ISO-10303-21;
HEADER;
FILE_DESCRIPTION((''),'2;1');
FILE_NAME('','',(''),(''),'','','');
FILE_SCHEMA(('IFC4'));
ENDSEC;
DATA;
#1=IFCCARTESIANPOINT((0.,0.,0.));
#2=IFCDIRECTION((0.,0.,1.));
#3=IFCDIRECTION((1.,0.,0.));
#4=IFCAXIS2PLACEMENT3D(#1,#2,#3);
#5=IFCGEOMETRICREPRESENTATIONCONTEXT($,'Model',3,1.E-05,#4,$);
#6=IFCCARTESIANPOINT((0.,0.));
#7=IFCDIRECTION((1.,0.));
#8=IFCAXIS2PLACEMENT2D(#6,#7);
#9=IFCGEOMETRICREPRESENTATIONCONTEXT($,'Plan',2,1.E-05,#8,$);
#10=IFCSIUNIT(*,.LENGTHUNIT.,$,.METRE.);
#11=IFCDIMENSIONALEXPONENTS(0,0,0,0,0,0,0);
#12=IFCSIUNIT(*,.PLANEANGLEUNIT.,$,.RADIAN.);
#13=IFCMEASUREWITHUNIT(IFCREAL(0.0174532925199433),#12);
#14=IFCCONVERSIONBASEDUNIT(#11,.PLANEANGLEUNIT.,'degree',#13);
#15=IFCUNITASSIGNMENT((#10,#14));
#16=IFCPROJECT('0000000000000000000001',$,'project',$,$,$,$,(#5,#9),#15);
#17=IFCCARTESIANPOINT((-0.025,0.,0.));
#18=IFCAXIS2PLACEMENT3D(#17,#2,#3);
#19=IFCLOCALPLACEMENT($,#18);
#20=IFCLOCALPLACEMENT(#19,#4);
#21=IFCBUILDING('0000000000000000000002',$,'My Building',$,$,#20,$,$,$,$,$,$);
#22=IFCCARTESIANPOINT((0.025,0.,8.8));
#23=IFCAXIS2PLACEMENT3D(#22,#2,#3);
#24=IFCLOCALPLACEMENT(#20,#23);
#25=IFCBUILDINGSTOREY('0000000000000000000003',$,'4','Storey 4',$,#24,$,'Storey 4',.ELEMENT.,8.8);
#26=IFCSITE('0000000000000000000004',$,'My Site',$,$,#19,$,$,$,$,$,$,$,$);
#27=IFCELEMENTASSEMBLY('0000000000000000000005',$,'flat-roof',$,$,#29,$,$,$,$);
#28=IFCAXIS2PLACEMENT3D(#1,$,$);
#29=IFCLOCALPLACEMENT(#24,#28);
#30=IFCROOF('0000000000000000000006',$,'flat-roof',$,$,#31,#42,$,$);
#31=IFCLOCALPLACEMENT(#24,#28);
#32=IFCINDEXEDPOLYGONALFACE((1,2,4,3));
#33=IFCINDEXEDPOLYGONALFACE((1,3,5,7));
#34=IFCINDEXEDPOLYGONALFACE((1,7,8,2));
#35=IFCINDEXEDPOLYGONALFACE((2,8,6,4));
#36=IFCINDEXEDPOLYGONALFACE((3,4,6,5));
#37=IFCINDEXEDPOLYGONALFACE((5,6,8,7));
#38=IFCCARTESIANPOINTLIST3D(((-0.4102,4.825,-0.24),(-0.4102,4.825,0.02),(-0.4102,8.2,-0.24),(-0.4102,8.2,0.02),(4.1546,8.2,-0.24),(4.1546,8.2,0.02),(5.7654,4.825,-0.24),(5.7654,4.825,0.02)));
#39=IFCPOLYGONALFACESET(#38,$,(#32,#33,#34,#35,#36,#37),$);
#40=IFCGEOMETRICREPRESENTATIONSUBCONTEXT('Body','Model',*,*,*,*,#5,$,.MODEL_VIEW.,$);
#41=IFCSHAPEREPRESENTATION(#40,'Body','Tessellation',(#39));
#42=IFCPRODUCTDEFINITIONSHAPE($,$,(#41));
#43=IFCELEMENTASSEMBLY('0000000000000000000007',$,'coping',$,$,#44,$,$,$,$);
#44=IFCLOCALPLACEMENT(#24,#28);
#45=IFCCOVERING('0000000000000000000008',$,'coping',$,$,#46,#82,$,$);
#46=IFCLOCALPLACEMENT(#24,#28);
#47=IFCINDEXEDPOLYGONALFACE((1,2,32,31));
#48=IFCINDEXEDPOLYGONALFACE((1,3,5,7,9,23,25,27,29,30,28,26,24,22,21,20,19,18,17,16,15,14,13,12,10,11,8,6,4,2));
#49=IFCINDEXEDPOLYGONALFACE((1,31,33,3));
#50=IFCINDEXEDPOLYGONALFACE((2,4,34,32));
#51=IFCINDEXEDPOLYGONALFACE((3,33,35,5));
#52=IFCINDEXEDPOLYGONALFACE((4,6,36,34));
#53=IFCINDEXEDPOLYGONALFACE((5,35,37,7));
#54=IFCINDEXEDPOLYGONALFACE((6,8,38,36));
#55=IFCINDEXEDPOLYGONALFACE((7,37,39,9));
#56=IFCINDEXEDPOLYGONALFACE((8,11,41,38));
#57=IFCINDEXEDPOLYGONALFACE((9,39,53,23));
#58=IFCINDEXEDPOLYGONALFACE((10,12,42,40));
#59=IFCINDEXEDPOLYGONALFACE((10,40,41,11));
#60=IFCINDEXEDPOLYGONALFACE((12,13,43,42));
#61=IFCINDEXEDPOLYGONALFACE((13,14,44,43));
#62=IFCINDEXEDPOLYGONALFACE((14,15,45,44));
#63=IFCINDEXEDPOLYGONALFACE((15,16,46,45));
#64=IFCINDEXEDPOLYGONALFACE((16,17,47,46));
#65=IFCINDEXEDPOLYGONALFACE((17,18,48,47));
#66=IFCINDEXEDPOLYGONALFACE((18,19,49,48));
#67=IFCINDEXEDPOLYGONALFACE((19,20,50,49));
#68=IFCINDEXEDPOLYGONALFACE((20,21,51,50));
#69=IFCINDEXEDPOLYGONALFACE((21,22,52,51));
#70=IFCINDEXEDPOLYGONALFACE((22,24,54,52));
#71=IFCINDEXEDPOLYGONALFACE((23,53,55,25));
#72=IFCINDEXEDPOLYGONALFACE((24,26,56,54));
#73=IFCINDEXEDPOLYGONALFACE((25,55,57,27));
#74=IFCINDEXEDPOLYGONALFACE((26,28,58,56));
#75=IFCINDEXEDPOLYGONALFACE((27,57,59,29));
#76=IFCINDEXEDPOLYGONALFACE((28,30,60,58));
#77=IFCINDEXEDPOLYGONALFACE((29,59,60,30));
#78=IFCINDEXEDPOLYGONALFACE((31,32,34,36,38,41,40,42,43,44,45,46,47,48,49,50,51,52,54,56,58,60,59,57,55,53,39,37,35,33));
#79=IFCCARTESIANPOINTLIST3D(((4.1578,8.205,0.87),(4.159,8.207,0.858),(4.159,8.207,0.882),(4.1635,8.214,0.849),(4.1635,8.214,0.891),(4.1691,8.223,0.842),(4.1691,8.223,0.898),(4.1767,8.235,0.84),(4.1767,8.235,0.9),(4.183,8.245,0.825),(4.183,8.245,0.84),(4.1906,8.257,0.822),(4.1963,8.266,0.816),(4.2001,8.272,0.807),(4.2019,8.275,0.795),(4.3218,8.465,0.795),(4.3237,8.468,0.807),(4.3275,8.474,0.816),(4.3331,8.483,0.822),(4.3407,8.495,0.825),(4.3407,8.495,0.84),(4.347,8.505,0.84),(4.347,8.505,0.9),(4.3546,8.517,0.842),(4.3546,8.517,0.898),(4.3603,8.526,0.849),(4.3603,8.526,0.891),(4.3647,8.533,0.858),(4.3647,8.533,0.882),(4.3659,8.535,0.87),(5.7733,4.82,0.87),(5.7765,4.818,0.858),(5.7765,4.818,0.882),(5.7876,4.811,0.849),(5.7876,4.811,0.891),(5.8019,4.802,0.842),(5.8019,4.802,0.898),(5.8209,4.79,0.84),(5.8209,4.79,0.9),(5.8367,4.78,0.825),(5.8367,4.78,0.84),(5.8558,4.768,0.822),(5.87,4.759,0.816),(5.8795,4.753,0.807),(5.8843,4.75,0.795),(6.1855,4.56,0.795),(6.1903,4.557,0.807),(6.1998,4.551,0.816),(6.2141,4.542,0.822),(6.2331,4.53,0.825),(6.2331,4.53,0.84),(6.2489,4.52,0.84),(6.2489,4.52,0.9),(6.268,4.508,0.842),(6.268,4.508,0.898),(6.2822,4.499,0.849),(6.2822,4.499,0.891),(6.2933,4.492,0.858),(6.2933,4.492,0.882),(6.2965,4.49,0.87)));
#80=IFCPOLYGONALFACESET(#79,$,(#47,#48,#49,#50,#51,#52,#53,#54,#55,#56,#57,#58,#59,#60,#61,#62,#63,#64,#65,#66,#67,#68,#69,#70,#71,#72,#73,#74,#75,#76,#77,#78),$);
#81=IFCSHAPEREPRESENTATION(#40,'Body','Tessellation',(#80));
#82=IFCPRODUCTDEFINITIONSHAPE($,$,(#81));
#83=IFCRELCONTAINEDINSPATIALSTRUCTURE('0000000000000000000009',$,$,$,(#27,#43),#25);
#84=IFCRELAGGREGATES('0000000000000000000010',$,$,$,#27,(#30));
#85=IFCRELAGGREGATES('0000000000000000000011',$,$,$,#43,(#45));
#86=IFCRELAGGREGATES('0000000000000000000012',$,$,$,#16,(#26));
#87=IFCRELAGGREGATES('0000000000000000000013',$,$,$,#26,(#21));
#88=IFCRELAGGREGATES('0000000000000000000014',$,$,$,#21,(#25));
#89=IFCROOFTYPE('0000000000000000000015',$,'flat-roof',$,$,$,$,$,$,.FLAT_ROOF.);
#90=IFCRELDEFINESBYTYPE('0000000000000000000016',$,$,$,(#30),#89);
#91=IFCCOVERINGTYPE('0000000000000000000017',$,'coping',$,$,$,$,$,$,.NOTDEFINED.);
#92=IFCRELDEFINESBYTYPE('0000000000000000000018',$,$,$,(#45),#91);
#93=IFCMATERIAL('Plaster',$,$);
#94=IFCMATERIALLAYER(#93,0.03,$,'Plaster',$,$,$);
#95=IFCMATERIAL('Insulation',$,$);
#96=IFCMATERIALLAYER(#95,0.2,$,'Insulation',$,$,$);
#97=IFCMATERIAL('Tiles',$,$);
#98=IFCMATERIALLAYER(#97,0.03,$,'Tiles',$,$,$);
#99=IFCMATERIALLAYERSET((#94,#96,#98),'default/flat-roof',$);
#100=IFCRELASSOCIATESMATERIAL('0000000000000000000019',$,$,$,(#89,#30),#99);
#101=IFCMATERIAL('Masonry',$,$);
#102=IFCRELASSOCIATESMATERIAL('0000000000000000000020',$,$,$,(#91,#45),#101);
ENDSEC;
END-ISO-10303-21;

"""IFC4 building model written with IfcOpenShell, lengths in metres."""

from ifc_helpers import new_model, entity, si_unit, converted_unit, frame, origin, origin_with_axes, origin_2d_with_axis, place, context, subcontext, project, spatial, polyline, outline, extrude, clip, halfspace, material, layer, layer_set, layer_usage, material_profile, profile_set, profile_usage, type_object, element, aggregate, save


model = new_model("IFC4")

# Units and contexts
model_context = context("Model", 3, precision=1e-05, world=origin_with_axes())
plan_context = context("Plan", 2, precision=1e-05, world=origin_2d_with_axis())
body_context = subcontext(model_context, "Body", "Model", "MODEL_VIEW")
ifc_project = project(units=[si_unit("LENGTHUNIT", "METRE"), converted_unit("PLANEANGLEUNIT", "degree", entity("IfcReal", 0.0174532925199433), si_unit("PLANEANGLEUNIT", "RADIAN"), dimensions=[0, 0, 0, 0, 0, 0, 0])], contexts=[model_context, plan_context])

# Site, building, storey
site_placement = place(None, frame((-0.025, 0.0, 0.0), z_axis=(0.0, 0.0, 1.0), x_axis=(1.0, 0.0, 0.0)))
site = spatial("IfcSite", under=ifc_project, at=site_placement, Name="My Site")
building_placement = place(site_placement, origin_with_axes())
building = spatial("IfcBuilding", under=site, at=building_placement, Name="My Building")
storey_placement = place(building_placement, frame((0.025, 0.0, 8.8), z_axis=(0.0, 0.0, 1.0), x_axis=(1.0, 0.0, 0.0)))
storey = spatial("IfcBuildingStorey", under=building, at=storey_placement, Name="4", Description="Storey 4", LongName="Storey 4", CompositionType="ELEMENT", Elevation=8.8)

# Shared definitions
ifc_material_1 = material(Name="Masonry")

# Element assembly, roof
assembly_1_placement = place(storey_placement, frame((0.0, 0.0, -8.8), z_axis=(0.0, 0.0, 1.0), x_axis=(1.0, 0.0, 0.0)))
assembly_1 = element("IfcElementAssembly", 1, at=assembly_1_placement, inside=storey, Name="flat-roof")
ifc_material_2 = material(Name="Plaster")
ifc_layer_1 = layer(ifc_material_2, 0.03, Name="Plaster")
ifc_material_3 = material(Name="Insulation")
ifc_layer_2 = layer(ifc_material_3, 0.2, Name="Insulation")
ifc_material_4 = material(Name="Tiles")
ifc_layer_3 = layer(ifc_material_4, 0.03, Name="Tiles")
ifc_layer_set = layer_set([ifc_layer_1, ifc_layer_2, ifc_layer_3], Name="default/flat-roof")
ifc_layer_usage = layer_usage(ifc_layer_set, "AXIS3", "POSITIVE", 0.0)
roof_type = type_object("IfcRoofType", Name="flat-roof", PredefinedType="FLAT_ROOF", material=ifc_layer_set)
roof_placement = place(assembly_1_placement, frame((4.1546, 8.2, 8.56), z_axis=(0.0, 0.0, 1.0), x_axis=(1.0, 0.0, 0.0)))
roof = element("IfcRoof", 2, at=roof_placement, type_object=roof_type, material=ifc_layer_usage, Name="flat-roof", context=body_context, shape_type="SweptSolid", body=[
    extrude(outline(polyline([(0.0, 0.0), (1.6108, -3.375), (-4.5648, -3.375), (-4.5648, 0.0), (0.0, 0.0)])), origin(), (0.0, 0.0, 1.0), 0.26),
])
aggregate(assembly_1, [roof])

# Element assembly, covering
assembly_2_placement = place(storey_placement, frame((0.0, 0.0, -8.8), z_axis=(0.0, 0.0, 1.0), x_axis=(1.0, 0.0, 0.0)))
assembly_2 = element("IfcElementAssembly", 3, at=assembly_2_placement, inside=storey, Name="coping")
ifc_material_profile_1 = material_profile(ifc_material_1, outline(polyline([(0.265, 0.795), (0.268, 0.807), (0.274, 0.816), (0.283, 0.822), (0.295, 0.825), (0.295, 0.84), (0.305, 0.84), (0.317, 0.842), (0.326, 0.849), (0.333, 0.858), (0.335, 0.87), (0.333, 0.882), (0.326, 0.891), (0.317, 0.898), (0.305, 0.9), (0.035, 0.9), (0.023, 0.898), (0.014, 0.891), (0.007, 0.882), (0.005, 0.87), (0.007, 0.858), (0.014, 0.849), (0.023, 0.842), (0.035, 0.84), (0.045, 0.84), (0.045, 0.825), (0.057, 0.822), (0.066, 0.816), (0.072, 0.807), (0.075, 0.795), (0.265, 0.795)])))
ifc_profile_set_1 = profile_set([ifc_material_profile_1])
covering_type_1 = type_object("IfcCoveringType", Name="coping", PredefinedType="NOTDEFINED", material=ifc_profile_set_1)
ifc_profile_usage_1 = profile_usage(ifc_profile_set_1)
covering_1_placement = place(assembly_2_placement, frame((3.7239, 9.1025, 8.8), z_axis=(0.430724, -0.902484, 0.0), x_axis=(0.902484, 0.430724, 0.0)))
covering_1 = element("IfcCovering", 4, at=covering_1_placement, type_object=covering_type_1, material=ifc_profile_usage_1, Name="coping", context=body_context, shape_type="Clipping", body=[
    clip(clip(extrude(outline(polyline([(0.265, 0.795), (0.268, 0.807), (0.274, 0.816), (0.283, 0.822), (0.295, 0.825), (0.295, 0.84), (0.305, 0.84), (0.317, 0.842), (0.326, 0.849), (0.333, 0.858), (0.335, 0.87), (0.333, 0.882), (0.326, 0.891), (0.317, 0.898), (0.305, 0.9), (0.035, 0.9), (0.023, 0.898), (0.014, 0.891), (0.007, 0.882), (0.005, 0.87), (0.007, 0.858), (0.014, 0.849), (0.023, 0.842), (0.035, 0.84), (0.045, 0.84), (0.045, 0.825), (0.057, 0.822), (0.066, 0.816), (0.072, 0.807), (0.075, 0.795), (0.265, 0.795)])), origin_with_axes(), (0.0, 0.0, 1.0), 5.7397), halfspace(frame((0.0, -8.8, 1.0), z_axis=(-0.533515, 0.0, -0.845791), x_axis=(0.0, 1.0, 0.0)), False)), halfspace(frame((0.0, -8.8, 4.7397), z_axis=(-0.845791, 0.0, 0.533515), x_axis=(0.0, 1.0, 0.0)), False)),
])
aggregate(assembly_2, [covering_1])

save(model, "model.ifc")
